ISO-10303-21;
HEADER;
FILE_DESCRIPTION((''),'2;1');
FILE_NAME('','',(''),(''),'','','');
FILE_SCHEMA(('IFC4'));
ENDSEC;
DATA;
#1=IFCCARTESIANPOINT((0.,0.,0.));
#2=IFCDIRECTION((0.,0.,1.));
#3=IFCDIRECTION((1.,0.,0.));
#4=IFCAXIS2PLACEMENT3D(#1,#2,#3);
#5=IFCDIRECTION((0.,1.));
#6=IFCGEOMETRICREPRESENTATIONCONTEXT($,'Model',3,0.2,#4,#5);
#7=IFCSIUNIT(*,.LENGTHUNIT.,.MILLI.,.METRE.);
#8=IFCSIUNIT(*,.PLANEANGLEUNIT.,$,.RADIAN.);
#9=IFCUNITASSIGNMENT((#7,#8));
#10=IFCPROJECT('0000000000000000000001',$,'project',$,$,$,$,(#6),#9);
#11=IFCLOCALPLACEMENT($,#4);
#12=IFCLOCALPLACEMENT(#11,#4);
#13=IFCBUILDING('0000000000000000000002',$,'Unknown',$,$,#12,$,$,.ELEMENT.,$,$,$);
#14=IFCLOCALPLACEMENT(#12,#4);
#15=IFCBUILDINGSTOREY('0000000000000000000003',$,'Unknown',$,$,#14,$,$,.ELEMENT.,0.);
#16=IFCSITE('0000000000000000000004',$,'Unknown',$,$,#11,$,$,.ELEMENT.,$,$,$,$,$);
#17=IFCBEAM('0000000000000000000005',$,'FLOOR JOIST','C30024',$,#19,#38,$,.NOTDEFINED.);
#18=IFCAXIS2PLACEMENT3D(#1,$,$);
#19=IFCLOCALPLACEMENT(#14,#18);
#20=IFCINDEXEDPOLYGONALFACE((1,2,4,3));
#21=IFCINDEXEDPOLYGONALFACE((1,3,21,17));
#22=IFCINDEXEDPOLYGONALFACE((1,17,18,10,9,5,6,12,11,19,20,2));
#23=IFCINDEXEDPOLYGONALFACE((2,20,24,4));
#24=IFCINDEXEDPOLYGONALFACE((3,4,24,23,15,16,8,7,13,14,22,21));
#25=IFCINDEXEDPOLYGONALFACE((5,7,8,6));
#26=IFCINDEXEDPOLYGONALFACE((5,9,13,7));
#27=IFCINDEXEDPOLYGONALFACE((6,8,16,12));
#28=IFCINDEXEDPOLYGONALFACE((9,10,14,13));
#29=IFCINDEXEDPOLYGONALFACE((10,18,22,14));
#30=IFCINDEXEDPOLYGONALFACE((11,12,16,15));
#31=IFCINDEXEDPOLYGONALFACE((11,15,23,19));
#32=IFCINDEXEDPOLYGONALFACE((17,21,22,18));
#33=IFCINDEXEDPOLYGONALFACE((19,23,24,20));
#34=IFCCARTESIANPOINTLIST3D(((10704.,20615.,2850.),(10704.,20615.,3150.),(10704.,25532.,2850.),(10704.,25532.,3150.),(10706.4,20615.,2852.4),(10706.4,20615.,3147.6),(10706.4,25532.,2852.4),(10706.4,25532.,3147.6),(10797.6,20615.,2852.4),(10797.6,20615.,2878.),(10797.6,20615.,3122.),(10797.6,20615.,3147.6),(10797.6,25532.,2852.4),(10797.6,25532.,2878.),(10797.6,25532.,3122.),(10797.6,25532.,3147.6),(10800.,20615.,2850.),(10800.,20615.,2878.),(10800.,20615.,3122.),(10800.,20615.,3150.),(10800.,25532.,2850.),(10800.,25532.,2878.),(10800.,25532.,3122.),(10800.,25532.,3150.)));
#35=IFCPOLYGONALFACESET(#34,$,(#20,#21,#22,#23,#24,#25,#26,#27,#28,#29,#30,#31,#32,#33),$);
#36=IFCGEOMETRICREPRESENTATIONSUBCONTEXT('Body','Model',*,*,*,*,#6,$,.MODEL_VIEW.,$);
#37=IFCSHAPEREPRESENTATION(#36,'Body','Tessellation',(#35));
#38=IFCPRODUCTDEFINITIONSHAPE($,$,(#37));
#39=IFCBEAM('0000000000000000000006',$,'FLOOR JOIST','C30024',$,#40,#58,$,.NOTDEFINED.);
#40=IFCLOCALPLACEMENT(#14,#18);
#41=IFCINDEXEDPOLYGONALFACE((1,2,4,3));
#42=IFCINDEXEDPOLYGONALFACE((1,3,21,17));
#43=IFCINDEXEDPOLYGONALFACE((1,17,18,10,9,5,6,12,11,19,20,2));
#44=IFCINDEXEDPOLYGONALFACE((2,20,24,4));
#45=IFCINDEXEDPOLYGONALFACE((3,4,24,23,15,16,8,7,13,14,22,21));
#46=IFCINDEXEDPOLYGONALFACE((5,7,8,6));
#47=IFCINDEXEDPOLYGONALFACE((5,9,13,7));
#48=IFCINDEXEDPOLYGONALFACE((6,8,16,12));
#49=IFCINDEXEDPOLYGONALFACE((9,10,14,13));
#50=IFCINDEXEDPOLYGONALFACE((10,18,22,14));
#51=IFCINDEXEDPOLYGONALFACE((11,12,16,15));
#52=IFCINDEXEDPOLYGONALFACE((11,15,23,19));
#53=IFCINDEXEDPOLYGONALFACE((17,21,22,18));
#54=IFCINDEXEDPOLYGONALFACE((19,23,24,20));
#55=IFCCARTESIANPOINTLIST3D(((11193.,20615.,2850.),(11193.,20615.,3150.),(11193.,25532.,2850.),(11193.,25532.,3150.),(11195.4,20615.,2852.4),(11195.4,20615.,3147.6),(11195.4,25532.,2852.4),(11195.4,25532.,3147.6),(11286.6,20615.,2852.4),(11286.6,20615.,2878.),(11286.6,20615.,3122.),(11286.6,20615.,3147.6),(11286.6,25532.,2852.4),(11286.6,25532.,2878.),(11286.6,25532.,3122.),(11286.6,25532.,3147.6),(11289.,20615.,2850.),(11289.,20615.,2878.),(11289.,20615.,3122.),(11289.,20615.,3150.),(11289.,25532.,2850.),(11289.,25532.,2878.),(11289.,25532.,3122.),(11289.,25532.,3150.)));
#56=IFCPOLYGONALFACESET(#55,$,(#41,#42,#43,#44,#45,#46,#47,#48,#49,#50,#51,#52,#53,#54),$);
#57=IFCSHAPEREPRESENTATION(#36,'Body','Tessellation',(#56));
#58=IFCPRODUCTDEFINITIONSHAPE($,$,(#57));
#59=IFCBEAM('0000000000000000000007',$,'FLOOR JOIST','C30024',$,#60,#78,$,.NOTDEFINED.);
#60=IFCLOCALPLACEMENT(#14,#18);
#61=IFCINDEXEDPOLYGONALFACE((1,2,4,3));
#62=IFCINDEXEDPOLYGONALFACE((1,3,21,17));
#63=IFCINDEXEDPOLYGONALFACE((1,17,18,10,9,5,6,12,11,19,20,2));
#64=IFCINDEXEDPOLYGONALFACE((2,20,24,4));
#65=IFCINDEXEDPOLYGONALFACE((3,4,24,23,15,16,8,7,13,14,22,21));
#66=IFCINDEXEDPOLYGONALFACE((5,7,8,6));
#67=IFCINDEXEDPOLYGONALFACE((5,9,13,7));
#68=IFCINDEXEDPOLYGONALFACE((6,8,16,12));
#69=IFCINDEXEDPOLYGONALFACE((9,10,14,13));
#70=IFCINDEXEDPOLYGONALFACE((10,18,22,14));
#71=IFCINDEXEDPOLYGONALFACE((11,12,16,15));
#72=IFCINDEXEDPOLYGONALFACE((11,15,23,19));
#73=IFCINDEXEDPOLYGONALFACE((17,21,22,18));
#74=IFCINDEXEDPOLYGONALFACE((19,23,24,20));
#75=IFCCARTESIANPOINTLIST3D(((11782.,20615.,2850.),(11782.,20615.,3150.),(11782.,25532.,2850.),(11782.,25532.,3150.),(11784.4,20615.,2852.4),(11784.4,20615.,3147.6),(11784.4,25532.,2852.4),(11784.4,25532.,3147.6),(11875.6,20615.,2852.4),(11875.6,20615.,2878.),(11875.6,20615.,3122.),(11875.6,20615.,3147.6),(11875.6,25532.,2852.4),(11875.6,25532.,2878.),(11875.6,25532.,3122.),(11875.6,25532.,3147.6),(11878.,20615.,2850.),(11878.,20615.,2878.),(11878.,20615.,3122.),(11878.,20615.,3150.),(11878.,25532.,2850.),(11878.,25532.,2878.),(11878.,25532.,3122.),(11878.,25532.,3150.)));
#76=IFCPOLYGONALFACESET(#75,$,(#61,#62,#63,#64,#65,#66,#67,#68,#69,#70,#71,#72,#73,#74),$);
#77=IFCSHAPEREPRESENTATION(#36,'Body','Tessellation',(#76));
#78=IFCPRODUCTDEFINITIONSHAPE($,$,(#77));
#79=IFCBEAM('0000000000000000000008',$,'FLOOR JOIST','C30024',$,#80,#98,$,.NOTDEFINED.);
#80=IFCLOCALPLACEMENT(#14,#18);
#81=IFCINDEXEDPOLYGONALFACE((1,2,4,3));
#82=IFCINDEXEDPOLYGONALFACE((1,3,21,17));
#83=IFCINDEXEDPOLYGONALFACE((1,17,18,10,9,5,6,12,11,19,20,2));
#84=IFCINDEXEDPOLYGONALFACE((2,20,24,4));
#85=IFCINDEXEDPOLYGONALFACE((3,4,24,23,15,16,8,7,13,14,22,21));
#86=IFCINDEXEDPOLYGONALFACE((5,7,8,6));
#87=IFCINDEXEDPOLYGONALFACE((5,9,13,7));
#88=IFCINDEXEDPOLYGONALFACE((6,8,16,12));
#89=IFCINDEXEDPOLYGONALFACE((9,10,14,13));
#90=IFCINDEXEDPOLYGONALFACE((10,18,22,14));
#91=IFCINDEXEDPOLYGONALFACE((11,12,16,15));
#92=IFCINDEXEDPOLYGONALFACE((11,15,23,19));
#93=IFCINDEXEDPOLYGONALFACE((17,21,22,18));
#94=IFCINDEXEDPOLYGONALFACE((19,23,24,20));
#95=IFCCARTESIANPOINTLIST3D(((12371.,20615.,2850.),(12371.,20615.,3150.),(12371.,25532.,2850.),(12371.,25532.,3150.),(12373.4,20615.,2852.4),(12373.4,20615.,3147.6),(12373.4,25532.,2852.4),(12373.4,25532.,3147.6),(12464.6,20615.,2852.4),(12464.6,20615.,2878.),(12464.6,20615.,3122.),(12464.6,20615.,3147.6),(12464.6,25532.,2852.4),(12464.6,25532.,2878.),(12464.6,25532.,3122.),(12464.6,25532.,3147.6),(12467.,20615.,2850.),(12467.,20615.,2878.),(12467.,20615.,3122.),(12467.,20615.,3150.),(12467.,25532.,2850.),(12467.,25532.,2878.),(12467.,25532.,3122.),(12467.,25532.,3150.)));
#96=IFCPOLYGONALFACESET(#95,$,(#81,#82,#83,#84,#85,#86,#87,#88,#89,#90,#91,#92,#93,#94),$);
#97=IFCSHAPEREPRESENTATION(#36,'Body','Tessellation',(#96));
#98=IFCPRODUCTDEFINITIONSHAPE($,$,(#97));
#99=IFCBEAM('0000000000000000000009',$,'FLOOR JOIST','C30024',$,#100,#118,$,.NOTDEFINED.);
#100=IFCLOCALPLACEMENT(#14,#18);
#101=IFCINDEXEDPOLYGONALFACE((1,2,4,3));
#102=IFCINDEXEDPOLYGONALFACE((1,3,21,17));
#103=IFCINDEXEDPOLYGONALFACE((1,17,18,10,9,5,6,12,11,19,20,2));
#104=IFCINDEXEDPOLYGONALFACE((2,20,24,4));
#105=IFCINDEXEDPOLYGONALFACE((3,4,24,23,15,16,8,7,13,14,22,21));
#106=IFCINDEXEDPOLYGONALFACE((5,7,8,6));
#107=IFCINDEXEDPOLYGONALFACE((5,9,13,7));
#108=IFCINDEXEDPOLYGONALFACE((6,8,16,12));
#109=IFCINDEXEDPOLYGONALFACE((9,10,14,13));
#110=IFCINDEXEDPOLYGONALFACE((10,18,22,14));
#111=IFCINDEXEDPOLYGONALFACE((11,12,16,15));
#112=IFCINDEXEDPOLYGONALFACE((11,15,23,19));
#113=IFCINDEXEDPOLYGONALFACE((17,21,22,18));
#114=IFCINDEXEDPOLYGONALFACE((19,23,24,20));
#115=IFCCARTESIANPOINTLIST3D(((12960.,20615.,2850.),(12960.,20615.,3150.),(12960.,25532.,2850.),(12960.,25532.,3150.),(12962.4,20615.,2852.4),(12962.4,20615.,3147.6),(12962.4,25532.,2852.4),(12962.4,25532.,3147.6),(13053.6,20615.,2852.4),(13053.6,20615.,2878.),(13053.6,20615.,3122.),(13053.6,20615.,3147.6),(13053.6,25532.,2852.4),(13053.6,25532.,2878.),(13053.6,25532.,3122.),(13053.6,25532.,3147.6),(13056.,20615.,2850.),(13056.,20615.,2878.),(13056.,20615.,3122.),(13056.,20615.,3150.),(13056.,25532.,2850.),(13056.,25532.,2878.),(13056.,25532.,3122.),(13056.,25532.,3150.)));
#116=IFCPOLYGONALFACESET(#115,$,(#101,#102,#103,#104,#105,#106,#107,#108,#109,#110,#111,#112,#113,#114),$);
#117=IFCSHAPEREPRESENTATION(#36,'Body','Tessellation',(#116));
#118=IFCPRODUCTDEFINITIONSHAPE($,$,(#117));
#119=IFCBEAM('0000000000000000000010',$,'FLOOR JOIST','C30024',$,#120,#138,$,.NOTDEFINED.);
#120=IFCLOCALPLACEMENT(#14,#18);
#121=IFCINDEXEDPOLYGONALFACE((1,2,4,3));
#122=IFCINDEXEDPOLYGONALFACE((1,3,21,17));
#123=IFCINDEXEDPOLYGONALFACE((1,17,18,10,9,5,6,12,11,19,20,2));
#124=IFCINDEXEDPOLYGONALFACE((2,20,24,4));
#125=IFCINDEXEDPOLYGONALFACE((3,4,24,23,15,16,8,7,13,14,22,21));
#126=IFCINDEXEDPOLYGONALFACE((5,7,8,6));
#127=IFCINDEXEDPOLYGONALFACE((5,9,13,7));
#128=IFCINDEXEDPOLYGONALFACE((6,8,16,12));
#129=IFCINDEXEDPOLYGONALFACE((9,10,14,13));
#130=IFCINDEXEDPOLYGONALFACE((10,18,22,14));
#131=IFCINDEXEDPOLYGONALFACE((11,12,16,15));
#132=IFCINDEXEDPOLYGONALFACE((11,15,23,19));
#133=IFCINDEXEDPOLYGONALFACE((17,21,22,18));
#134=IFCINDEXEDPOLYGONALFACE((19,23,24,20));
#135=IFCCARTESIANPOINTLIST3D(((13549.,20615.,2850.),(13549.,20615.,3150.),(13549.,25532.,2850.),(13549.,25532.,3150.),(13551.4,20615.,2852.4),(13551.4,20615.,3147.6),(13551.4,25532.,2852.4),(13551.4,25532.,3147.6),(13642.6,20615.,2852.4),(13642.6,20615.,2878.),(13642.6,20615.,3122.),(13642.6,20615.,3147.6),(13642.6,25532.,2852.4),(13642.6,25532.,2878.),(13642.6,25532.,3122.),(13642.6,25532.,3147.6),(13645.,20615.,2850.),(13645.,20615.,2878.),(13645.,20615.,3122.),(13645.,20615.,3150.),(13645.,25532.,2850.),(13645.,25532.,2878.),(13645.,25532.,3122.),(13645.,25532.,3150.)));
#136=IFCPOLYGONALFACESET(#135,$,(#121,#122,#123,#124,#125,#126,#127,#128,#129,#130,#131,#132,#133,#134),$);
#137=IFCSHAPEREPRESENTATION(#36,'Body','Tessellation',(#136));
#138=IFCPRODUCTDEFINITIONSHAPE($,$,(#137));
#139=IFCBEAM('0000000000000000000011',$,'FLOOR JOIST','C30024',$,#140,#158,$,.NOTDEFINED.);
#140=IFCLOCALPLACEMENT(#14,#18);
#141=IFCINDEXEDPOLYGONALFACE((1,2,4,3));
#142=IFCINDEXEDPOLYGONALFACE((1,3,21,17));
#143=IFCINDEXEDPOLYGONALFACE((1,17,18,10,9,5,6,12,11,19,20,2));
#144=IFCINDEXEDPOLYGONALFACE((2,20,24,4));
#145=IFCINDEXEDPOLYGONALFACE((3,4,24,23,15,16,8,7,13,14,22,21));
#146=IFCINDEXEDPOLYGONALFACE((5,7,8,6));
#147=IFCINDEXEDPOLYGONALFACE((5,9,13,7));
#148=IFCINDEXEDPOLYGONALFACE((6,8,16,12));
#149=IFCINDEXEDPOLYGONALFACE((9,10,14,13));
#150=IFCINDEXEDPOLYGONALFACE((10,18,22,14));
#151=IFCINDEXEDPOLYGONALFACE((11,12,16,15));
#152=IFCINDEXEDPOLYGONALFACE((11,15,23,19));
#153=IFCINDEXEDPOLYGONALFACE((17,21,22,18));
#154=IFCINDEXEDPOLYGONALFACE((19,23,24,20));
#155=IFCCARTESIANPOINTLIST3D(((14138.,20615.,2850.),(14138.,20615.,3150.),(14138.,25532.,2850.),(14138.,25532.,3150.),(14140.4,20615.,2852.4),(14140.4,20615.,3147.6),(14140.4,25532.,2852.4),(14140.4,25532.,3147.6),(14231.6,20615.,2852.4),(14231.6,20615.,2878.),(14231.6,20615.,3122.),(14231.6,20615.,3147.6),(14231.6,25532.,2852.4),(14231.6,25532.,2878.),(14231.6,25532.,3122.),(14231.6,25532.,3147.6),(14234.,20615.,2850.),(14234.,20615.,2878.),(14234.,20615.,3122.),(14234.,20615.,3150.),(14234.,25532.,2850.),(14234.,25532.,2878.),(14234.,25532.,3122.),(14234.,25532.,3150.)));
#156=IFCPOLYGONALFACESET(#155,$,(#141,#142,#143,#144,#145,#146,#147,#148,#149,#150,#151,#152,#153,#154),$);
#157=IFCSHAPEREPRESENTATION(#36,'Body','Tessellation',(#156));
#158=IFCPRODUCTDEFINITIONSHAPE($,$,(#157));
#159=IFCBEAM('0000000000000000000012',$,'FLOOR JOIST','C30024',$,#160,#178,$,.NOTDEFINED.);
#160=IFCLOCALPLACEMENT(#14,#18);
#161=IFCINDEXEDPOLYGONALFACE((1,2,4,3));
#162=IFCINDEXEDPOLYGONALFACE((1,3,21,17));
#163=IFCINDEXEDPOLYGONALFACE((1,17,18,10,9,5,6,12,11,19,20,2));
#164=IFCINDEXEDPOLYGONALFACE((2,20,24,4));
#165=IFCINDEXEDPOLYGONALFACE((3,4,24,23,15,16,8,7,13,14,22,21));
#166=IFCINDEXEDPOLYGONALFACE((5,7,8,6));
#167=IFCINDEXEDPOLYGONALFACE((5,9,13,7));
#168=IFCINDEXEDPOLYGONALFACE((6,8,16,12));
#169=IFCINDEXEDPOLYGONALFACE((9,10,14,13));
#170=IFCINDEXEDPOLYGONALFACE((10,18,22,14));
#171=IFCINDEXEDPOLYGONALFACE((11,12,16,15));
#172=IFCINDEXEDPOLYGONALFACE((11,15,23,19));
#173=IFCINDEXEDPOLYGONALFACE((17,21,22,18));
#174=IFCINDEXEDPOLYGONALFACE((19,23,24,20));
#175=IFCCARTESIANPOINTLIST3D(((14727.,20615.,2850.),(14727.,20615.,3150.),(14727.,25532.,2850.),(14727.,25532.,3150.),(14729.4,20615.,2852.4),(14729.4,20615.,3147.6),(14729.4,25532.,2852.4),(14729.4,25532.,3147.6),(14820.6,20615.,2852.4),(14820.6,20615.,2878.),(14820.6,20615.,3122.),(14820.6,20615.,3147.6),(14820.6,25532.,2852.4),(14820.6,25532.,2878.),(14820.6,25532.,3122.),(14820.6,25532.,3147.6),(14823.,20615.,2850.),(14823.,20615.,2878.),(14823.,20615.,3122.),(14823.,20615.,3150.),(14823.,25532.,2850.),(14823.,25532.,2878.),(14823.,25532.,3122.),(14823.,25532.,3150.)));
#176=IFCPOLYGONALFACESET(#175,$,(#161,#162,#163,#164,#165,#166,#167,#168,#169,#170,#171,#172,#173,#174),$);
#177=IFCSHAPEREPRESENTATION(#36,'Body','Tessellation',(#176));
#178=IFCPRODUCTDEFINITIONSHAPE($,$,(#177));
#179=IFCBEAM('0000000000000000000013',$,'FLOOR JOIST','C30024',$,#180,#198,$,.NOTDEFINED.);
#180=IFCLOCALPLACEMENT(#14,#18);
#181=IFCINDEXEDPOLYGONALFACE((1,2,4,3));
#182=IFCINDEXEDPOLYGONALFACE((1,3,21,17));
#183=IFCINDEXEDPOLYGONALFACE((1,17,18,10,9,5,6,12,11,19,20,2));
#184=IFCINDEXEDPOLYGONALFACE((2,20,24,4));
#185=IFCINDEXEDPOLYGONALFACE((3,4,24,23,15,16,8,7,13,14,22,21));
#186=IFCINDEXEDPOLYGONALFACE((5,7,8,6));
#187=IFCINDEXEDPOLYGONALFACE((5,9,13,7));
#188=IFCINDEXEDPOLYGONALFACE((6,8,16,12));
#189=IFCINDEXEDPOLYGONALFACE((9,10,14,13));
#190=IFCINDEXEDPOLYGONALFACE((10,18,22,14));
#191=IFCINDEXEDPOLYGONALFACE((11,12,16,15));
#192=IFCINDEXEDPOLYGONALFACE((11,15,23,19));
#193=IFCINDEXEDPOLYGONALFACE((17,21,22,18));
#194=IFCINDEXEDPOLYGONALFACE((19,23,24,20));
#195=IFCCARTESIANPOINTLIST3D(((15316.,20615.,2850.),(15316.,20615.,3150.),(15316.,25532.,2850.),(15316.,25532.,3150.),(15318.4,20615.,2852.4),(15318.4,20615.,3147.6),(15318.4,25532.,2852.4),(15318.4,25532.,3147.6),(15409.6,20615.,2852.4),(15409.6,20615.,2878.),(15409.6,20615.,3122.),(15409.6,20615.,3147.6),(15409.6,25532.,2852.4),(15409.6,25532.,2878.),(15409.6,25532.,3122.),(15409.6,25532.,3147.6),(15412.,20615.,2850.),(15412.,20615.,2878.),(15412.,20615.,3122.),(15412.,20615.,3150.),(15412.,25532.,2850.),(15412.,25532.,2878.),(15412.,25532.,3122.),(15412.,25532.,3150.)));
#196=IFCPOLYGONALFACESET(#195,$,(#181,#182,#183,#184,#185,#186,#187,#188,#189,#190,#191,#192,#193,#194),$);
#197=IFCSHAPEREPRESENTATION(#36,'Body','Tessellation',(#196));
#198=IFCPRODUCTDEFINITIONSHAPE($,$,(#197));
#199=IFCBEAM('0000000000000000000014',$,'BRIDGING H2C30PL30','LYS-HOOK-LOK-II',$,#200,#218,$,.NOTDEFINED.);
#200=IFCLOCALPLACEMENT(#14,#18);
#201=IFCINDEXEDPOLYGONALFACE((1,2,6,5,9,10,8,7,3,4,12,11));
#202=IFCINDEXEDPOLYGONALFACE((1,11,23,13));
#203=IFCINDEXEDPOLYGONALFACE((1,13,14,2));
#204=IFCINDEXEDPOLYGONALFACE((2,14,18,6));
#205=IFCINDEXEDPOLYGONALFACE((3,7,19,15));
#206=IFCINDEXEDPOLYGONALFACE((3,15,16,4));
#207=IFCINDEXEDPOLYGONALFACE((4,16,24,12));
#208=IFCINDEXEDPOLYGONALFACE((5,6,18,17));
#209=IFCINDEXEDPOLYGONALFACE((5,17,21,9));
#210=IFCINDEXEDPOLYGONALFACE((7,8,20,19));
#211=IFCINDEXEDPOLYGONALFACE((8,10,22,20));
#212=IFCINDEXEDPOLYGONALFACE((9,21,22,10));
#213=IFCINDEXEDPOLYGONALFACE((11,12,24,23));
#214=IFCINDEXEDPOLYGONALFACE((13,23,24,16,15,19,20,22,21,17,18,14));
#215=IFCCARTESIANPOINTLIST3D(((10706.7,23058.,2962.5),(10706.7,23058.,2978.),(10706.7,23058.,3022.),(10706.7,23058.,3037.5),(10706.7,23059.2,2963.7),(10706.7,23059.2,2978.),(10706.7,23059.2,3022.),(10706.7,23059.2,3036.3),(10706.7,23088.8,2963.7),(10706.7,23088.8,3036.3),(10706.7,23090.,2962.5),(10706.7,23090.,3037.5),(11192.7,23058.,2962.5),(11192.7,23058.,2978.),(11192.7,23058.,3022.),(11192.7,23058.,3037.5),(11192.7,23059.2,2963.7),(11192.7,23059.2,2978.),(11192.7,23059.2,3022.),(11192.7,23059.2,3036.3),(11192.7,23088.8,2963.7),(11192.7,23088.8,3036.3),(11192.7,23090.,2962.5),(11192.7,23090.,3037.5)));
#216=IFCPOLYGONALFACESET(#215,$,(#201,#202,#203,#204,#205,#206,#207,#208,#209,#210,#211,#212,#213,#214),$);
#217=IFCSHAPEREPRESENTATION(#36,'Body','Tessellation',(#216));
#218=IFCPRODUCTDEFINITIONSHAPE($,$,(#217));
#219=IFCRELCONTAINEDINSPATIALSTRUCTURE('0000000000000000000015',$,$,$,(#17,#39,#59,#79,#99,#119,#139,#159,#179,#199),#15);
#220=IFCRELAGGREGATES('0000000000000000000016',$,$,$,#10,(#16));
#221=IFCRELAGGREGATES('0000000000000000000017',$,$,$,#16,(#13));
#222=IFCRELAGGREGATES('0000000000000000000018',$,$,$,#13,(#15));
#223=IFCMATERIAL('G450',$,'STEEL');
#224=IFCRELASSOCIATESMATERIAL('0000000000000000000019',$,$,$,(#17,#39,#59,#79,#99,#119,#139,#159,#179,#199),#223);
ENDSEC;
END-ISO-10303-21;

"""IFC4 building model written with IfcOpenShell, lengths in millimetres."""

from ifc_helpers import new_model, si_unit, direction, frame, origin_with_axes, place, context, subcontext, project, spatial, line, indexed_curve, outline, extrude, material, element, save


model = new_model("IFC4")

# Units and contexts
model_context = context("Model", 3, precision=0.2, world=origin_with_axes(), true_north=direction((0.0, 1.0)))
body_context = subcontext(model_context, "Body", "Model", "MODEL_VIEW")
ifc_project = project(units=[si_unit("LENGTHUNIT", "METRE", prefix="MILLI"), si_unit("PLANEANGLEUNIT", "RADIAN")], contexts=[model_context])

# Site, building, storey
site_placement = place(None, origin_with_axes())
site = spatial("IfcSite", under=ifc_project, at=site_placement, Name="Unknown", CompositionType="ELEMENT")
building_placement = place(site_placement, origin_with_axes())
building = spatial("IfcBuilding", under=site, at=building_placement, Name="Unknown", CompositionType="ELEMENT")
storey_placement = place(building_placement, origin_with_axes())
storey = spatial("IfcBuildingStorey", under=building, at=storey_placement, Name="Unknown", CompositionType="ELEMENT", Elevation=0.0)

# Beams
ifc_material_1 = material(Name="G450", Category="STEEL")
for number, where, z_axis, x_axis, name in (
    (1, (10752.0, 20615.0, 3000.0), (1.0, 0.0, 0.0), (0.0, 1.0, 0.0), "FLOOR JOIST"),
    (2, (11241.0, 20615.0, 3000.0), (1.0, 0.0, 0.0), (0.0, 1.0, 0.0), "FLOOR JOIST"),
    (3, (11830.0, 20615.0, 3000.0), (1.0, 0.0, 0.0), (0.0, 1.0, 0.0), "FLOOR JOIST"),
    (4, (12419.0, 20615.0, 3000.0), (1.0, 0.0, 0.0), (0.0, 1.0, 0.0), "FLOOR JOIST"),
    (5, (13008.0, 20615.0, 3000.0), (1.0, 0.0, 0.0), (0.0, 1.0, 0.0), "FLOOR JOIST"),
    (6, (13597.0, 20615.0, 3000.0), (1.0, 0.0, 0.0), (0.0, 1.0, 0.0), "FLOOR JOIST"),
    (7, (14186.0, 20615.0, 3000.0), (1.0, 0.0, 0.0), (0.0, 1.0, 0.0), "FLOOR JOIST"),
    (8, (14775.0, 20615.0, 3000.0), (1.0, 0.0, 0.0), (0.0, 1.0, 0.0), "FLOOR JOIST"),
    (9, (15364.0, 20615.0, 3000.0), (1.0, 0.0, 0.0), (0.0, 1.0, 0.0), "FLOOR JOIST"),
):
    element("IfcBeam", number, at=place(storey_placement, frame(where, z_axis=z_axis, x_axis=x_axis)), inside=storey, material=ifc_material_1, Name=name, Description="C30024", PredefinedType="NOTDEFINED", context=body_context, shape_type="SolidModel", body=[
        extrude(outline(indexed_curve([(48.0, -150.0), (48.0, -122.0), (45.6, -122.0), (45.6, -147.6), (-45.6, -147.6), (-45.6, 147.6), (45.6, 147.6), (45.6, 122.0), (48.0, 122.0), (48.0, 150.0), (-48.0, 150.0), (-48.0, -150.0)], segments=[line(1, 2, 3, 4, 5, 6, 7, 8, 9, 10, 11, 12, 1)])), frame((0.0, 0.0, 0.0), z_axis=(-1.0, 0.0, 0.0), x_axis=(0.0, 0.0, 1.0)), (0.0, 0.0, -1.0), 4917.0),
    ])
beam_placement = place(storey_placement, frame((10706.7, 23074.0, 3000.0), z_axis=(0.0, -1.0, 0.0), x_axis=(1.0, 0.0, 0.0)))
element("IfcBeam", 10, at=beam_placement, inside=storey, material=ifc_material_1, Name="BRIDGING H2C30PL30", Description="LYS-HOOK-LOK-II", PredefinedType="NOTDEFINED", context=body_context, shape_type="SolidModel", body=[
    extrude(outline(indexed_curve([(16.0, -37.5), (16.0, -22.0), (14.8, -22.0), (14.8, -36.3), (-14.8, -36.3), (-14.8, 36.3), (14.8, 36.3), (14.8, 22.0), (16.0, 22.0), (16.0, 37.5), (-16.0, 37.5), (-16.0, -37.5)], segments=[line(1, 2, 3, 4, 5, 6, 7, 8, 9, 10, 11, 12, 1)])), frame((0.0, 0.0, 0.0), z_axis=(-1.0, 0.0, 0.0), x_axis=(0.0, 0.0, 1.0)), (0.0, 0.0, -1.0), 486.0),
])

save(model, "model.ifc")
